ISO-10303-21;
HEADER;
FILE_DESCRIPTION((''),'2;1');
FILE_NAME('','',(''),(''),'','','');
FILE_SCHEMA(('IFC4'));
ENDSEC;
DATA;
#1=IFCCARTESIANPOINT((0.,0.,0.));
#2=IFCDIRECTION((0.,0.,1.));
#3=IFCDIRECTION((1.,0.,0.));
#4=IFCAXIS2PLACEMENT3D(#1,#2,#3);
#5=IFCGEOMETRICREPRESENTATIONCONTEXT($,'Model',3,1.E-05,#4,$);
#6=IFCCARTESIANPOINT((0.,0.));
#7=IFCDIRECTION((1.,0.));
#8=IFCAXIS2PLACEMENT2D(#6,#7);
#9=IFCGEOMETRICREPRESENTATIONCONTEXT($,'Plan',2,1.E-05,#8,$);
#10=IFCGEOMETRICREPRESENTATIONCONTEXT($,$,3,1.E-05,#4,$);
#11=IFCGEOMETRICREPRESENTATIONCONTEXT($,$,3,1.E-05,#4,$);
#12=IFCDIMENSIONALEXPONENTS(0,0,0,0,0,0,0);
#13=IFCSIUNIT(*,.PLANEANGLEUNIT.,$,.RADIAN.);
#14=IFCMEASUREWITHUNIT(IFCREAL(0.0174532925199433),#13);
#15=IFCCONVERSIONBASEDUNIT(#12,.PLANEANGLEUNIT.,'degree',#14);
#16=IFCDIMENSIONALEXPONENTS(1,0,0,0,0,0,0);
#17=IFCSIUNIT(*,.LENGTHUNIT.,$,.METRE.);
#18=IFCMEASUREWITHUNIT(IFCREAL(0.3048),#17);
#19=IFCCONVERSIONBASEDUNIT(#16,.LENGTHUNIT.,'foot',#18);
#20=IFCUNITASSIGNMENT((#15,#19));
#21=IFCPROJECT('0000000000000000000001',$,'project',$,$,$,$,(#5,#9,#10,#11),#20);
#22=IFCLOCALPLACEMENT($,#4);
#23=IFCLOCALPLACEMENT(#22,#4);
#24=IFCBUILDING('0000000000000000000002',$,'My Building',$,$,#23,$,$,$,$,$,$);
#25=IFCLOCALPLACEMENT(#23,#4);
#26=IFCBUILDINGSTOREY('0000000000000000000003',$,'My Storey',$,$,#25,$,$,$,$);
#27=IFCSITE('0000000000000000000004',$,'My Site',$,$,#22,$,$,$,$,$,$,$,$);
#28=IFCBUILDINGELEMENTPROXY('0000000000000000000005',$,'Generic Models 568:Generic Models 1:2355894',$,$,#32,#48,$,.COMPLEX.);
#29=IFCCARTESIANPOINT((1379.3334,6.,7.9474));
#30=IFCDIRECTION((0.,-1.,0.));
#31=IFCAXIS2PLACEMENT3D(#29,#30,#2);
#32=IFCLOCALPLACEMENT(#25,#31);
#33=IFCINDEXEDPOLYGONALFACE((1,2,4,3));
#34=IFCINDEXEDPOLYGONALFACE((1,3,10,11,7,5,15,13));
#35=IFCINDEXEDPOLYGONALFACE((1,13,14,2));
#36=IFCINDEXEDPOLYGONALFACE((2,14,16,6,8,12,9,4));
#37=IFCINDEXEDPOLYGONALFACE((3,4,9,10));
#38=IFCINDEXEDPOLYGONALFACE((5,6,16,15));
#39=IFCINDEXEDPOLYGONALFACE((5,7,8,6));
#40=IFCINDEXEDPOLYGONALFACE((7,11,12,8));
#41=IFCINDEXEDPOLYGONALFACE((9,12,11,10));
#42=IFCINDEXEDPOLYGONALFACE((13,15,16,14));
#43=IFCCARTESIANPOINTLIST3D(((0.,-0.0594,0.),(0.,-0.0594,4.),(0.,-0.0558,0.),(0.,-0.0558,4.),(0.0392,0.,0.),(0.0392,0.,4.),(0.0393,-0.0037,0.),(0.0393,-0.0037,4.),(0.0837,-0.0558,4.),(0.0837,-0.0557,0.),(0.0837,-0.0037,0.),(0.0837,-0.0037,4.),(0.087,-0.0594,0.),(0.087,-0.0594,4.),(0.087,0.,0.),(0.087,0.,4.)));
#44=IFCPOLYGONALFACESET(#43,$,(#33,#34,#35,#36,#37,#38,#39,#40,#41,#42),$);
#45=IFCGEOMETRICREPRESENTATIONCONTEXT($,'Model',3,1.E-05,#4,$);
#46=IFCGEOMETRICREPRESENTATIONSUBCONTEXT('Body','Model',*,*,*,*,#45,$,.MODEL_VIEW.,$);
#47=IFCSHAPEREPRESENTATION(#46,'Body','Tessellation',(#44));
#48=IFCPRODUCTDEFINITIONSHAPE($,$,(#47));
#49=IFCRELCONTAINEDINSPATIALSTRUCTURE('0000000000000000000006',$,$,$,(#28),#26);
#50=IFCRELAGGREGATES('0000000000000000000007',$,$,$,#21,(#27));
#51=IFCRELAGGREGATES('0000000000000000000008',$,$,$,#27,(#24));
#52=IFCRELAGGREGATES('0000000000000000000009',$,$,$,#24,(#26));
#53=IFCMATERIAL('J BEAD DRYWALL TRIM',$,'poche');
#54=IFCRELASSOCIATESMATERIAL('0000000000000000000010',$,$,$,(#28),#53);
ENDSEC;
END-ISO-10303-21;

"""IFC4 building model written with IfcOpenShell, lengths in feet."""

from ifc_helpers import new_model, entity, si_unit, converted_unit, frame, origin_with_axes, origin_2d_with_axis, place, context, subcontext, project, spatial, polyline, outline, extrude, material, element, save


model = new_model("IFC4")

# Units and contexts
model_context_1 = context("Model", 3, precision=1e-05, world=origin_with_axes())
plan_context = context("Plan", 2, precision=1e-05, world=origin_2d_with_axis())
model_context_2 = context("Model", 3, precision=1e-05, world=origin_with_axes())
context_of_model_1 = context(None, 3, precision=1e-05, world=origin_with_axes())
context_of_model_2 = context(None, 3, precision=1e-05, world=origin_with_axes())
body_context = subcontext(model_context_2, "Body", "Model", "MODEL_VIEW")
ifc_project = project(units=[converted_unit("PLANEANGLEUNIT", "degree", entity("IfcReal", 0.0174532925199433), si_unit("PLANEANGLEUNIT", "RADIAN"), dimensions=[0, 0, 0, 0, 0, 0, 0]), converted_unit("LENGTHUNIT", "foot", entity("IfcReal", 0.3048), si_unit("LENGTHUNIT", "METRE"), dimensions=[1, 0, 0, 0, 0, 0, 0])], contexts=[model_context_1, plan_context, context_of_model_1, context_of_model_2])

# Site, building, storey
site_placement = place(None, origin_with_axes())
site = spatial("IfcSite", under=ifc_project, at=site_placement, Name="My Site")
building_placement = place(site_placement, origin_with_axes())
building = spatial("IfcBuilding", under=site, at=building_placement, Name="My Building")
storey_placement = place(building_placement, origin_with_axes())
storey = spatial("IfcBuildingStorey", under=building, at=storey_placement, Name="My Storey")

# Building element proxy
ifc_material_1 = material(Name="J BEAD DRYWALL TRIM", Category="poche")
proxy_1_placement = place(storey_placement, frame((1379.3334, 6.0, 7.9474), z_axis=(0.0, -1.0, 0.0), x_axis=(0.0, 0.0, 1.0)))
element("IfcBuildingElementProxy", 1, at=proxy_1_placement, inside=storey, material=ifc_material_1, Name="Generic Models 568:Generic Models 1:2355894", PredefinedType="COMPLEX", context=body_context, shape_type="SweptSolid", body=[
    extrude(outline(polyline([(-0.0345, -0.0297), (0.0525, -0.0297), (0.0525, -0.026), (-0.0313, -0.026), (-0.0313, 0.026), (0.0132, 0.026), (0.0133, 0.0297), (-0.0345, 0.0297), (-0.0345, -0.0297)])), frame((0.0525, -0.0297, 0.0), z_axis=(0.0, 0.0, -1.0), x_axis=(-1.0, 0.0, 0.0)), (0.0, 0.0, -1.0), 4.0),
])

save(model, "model.ifc")
